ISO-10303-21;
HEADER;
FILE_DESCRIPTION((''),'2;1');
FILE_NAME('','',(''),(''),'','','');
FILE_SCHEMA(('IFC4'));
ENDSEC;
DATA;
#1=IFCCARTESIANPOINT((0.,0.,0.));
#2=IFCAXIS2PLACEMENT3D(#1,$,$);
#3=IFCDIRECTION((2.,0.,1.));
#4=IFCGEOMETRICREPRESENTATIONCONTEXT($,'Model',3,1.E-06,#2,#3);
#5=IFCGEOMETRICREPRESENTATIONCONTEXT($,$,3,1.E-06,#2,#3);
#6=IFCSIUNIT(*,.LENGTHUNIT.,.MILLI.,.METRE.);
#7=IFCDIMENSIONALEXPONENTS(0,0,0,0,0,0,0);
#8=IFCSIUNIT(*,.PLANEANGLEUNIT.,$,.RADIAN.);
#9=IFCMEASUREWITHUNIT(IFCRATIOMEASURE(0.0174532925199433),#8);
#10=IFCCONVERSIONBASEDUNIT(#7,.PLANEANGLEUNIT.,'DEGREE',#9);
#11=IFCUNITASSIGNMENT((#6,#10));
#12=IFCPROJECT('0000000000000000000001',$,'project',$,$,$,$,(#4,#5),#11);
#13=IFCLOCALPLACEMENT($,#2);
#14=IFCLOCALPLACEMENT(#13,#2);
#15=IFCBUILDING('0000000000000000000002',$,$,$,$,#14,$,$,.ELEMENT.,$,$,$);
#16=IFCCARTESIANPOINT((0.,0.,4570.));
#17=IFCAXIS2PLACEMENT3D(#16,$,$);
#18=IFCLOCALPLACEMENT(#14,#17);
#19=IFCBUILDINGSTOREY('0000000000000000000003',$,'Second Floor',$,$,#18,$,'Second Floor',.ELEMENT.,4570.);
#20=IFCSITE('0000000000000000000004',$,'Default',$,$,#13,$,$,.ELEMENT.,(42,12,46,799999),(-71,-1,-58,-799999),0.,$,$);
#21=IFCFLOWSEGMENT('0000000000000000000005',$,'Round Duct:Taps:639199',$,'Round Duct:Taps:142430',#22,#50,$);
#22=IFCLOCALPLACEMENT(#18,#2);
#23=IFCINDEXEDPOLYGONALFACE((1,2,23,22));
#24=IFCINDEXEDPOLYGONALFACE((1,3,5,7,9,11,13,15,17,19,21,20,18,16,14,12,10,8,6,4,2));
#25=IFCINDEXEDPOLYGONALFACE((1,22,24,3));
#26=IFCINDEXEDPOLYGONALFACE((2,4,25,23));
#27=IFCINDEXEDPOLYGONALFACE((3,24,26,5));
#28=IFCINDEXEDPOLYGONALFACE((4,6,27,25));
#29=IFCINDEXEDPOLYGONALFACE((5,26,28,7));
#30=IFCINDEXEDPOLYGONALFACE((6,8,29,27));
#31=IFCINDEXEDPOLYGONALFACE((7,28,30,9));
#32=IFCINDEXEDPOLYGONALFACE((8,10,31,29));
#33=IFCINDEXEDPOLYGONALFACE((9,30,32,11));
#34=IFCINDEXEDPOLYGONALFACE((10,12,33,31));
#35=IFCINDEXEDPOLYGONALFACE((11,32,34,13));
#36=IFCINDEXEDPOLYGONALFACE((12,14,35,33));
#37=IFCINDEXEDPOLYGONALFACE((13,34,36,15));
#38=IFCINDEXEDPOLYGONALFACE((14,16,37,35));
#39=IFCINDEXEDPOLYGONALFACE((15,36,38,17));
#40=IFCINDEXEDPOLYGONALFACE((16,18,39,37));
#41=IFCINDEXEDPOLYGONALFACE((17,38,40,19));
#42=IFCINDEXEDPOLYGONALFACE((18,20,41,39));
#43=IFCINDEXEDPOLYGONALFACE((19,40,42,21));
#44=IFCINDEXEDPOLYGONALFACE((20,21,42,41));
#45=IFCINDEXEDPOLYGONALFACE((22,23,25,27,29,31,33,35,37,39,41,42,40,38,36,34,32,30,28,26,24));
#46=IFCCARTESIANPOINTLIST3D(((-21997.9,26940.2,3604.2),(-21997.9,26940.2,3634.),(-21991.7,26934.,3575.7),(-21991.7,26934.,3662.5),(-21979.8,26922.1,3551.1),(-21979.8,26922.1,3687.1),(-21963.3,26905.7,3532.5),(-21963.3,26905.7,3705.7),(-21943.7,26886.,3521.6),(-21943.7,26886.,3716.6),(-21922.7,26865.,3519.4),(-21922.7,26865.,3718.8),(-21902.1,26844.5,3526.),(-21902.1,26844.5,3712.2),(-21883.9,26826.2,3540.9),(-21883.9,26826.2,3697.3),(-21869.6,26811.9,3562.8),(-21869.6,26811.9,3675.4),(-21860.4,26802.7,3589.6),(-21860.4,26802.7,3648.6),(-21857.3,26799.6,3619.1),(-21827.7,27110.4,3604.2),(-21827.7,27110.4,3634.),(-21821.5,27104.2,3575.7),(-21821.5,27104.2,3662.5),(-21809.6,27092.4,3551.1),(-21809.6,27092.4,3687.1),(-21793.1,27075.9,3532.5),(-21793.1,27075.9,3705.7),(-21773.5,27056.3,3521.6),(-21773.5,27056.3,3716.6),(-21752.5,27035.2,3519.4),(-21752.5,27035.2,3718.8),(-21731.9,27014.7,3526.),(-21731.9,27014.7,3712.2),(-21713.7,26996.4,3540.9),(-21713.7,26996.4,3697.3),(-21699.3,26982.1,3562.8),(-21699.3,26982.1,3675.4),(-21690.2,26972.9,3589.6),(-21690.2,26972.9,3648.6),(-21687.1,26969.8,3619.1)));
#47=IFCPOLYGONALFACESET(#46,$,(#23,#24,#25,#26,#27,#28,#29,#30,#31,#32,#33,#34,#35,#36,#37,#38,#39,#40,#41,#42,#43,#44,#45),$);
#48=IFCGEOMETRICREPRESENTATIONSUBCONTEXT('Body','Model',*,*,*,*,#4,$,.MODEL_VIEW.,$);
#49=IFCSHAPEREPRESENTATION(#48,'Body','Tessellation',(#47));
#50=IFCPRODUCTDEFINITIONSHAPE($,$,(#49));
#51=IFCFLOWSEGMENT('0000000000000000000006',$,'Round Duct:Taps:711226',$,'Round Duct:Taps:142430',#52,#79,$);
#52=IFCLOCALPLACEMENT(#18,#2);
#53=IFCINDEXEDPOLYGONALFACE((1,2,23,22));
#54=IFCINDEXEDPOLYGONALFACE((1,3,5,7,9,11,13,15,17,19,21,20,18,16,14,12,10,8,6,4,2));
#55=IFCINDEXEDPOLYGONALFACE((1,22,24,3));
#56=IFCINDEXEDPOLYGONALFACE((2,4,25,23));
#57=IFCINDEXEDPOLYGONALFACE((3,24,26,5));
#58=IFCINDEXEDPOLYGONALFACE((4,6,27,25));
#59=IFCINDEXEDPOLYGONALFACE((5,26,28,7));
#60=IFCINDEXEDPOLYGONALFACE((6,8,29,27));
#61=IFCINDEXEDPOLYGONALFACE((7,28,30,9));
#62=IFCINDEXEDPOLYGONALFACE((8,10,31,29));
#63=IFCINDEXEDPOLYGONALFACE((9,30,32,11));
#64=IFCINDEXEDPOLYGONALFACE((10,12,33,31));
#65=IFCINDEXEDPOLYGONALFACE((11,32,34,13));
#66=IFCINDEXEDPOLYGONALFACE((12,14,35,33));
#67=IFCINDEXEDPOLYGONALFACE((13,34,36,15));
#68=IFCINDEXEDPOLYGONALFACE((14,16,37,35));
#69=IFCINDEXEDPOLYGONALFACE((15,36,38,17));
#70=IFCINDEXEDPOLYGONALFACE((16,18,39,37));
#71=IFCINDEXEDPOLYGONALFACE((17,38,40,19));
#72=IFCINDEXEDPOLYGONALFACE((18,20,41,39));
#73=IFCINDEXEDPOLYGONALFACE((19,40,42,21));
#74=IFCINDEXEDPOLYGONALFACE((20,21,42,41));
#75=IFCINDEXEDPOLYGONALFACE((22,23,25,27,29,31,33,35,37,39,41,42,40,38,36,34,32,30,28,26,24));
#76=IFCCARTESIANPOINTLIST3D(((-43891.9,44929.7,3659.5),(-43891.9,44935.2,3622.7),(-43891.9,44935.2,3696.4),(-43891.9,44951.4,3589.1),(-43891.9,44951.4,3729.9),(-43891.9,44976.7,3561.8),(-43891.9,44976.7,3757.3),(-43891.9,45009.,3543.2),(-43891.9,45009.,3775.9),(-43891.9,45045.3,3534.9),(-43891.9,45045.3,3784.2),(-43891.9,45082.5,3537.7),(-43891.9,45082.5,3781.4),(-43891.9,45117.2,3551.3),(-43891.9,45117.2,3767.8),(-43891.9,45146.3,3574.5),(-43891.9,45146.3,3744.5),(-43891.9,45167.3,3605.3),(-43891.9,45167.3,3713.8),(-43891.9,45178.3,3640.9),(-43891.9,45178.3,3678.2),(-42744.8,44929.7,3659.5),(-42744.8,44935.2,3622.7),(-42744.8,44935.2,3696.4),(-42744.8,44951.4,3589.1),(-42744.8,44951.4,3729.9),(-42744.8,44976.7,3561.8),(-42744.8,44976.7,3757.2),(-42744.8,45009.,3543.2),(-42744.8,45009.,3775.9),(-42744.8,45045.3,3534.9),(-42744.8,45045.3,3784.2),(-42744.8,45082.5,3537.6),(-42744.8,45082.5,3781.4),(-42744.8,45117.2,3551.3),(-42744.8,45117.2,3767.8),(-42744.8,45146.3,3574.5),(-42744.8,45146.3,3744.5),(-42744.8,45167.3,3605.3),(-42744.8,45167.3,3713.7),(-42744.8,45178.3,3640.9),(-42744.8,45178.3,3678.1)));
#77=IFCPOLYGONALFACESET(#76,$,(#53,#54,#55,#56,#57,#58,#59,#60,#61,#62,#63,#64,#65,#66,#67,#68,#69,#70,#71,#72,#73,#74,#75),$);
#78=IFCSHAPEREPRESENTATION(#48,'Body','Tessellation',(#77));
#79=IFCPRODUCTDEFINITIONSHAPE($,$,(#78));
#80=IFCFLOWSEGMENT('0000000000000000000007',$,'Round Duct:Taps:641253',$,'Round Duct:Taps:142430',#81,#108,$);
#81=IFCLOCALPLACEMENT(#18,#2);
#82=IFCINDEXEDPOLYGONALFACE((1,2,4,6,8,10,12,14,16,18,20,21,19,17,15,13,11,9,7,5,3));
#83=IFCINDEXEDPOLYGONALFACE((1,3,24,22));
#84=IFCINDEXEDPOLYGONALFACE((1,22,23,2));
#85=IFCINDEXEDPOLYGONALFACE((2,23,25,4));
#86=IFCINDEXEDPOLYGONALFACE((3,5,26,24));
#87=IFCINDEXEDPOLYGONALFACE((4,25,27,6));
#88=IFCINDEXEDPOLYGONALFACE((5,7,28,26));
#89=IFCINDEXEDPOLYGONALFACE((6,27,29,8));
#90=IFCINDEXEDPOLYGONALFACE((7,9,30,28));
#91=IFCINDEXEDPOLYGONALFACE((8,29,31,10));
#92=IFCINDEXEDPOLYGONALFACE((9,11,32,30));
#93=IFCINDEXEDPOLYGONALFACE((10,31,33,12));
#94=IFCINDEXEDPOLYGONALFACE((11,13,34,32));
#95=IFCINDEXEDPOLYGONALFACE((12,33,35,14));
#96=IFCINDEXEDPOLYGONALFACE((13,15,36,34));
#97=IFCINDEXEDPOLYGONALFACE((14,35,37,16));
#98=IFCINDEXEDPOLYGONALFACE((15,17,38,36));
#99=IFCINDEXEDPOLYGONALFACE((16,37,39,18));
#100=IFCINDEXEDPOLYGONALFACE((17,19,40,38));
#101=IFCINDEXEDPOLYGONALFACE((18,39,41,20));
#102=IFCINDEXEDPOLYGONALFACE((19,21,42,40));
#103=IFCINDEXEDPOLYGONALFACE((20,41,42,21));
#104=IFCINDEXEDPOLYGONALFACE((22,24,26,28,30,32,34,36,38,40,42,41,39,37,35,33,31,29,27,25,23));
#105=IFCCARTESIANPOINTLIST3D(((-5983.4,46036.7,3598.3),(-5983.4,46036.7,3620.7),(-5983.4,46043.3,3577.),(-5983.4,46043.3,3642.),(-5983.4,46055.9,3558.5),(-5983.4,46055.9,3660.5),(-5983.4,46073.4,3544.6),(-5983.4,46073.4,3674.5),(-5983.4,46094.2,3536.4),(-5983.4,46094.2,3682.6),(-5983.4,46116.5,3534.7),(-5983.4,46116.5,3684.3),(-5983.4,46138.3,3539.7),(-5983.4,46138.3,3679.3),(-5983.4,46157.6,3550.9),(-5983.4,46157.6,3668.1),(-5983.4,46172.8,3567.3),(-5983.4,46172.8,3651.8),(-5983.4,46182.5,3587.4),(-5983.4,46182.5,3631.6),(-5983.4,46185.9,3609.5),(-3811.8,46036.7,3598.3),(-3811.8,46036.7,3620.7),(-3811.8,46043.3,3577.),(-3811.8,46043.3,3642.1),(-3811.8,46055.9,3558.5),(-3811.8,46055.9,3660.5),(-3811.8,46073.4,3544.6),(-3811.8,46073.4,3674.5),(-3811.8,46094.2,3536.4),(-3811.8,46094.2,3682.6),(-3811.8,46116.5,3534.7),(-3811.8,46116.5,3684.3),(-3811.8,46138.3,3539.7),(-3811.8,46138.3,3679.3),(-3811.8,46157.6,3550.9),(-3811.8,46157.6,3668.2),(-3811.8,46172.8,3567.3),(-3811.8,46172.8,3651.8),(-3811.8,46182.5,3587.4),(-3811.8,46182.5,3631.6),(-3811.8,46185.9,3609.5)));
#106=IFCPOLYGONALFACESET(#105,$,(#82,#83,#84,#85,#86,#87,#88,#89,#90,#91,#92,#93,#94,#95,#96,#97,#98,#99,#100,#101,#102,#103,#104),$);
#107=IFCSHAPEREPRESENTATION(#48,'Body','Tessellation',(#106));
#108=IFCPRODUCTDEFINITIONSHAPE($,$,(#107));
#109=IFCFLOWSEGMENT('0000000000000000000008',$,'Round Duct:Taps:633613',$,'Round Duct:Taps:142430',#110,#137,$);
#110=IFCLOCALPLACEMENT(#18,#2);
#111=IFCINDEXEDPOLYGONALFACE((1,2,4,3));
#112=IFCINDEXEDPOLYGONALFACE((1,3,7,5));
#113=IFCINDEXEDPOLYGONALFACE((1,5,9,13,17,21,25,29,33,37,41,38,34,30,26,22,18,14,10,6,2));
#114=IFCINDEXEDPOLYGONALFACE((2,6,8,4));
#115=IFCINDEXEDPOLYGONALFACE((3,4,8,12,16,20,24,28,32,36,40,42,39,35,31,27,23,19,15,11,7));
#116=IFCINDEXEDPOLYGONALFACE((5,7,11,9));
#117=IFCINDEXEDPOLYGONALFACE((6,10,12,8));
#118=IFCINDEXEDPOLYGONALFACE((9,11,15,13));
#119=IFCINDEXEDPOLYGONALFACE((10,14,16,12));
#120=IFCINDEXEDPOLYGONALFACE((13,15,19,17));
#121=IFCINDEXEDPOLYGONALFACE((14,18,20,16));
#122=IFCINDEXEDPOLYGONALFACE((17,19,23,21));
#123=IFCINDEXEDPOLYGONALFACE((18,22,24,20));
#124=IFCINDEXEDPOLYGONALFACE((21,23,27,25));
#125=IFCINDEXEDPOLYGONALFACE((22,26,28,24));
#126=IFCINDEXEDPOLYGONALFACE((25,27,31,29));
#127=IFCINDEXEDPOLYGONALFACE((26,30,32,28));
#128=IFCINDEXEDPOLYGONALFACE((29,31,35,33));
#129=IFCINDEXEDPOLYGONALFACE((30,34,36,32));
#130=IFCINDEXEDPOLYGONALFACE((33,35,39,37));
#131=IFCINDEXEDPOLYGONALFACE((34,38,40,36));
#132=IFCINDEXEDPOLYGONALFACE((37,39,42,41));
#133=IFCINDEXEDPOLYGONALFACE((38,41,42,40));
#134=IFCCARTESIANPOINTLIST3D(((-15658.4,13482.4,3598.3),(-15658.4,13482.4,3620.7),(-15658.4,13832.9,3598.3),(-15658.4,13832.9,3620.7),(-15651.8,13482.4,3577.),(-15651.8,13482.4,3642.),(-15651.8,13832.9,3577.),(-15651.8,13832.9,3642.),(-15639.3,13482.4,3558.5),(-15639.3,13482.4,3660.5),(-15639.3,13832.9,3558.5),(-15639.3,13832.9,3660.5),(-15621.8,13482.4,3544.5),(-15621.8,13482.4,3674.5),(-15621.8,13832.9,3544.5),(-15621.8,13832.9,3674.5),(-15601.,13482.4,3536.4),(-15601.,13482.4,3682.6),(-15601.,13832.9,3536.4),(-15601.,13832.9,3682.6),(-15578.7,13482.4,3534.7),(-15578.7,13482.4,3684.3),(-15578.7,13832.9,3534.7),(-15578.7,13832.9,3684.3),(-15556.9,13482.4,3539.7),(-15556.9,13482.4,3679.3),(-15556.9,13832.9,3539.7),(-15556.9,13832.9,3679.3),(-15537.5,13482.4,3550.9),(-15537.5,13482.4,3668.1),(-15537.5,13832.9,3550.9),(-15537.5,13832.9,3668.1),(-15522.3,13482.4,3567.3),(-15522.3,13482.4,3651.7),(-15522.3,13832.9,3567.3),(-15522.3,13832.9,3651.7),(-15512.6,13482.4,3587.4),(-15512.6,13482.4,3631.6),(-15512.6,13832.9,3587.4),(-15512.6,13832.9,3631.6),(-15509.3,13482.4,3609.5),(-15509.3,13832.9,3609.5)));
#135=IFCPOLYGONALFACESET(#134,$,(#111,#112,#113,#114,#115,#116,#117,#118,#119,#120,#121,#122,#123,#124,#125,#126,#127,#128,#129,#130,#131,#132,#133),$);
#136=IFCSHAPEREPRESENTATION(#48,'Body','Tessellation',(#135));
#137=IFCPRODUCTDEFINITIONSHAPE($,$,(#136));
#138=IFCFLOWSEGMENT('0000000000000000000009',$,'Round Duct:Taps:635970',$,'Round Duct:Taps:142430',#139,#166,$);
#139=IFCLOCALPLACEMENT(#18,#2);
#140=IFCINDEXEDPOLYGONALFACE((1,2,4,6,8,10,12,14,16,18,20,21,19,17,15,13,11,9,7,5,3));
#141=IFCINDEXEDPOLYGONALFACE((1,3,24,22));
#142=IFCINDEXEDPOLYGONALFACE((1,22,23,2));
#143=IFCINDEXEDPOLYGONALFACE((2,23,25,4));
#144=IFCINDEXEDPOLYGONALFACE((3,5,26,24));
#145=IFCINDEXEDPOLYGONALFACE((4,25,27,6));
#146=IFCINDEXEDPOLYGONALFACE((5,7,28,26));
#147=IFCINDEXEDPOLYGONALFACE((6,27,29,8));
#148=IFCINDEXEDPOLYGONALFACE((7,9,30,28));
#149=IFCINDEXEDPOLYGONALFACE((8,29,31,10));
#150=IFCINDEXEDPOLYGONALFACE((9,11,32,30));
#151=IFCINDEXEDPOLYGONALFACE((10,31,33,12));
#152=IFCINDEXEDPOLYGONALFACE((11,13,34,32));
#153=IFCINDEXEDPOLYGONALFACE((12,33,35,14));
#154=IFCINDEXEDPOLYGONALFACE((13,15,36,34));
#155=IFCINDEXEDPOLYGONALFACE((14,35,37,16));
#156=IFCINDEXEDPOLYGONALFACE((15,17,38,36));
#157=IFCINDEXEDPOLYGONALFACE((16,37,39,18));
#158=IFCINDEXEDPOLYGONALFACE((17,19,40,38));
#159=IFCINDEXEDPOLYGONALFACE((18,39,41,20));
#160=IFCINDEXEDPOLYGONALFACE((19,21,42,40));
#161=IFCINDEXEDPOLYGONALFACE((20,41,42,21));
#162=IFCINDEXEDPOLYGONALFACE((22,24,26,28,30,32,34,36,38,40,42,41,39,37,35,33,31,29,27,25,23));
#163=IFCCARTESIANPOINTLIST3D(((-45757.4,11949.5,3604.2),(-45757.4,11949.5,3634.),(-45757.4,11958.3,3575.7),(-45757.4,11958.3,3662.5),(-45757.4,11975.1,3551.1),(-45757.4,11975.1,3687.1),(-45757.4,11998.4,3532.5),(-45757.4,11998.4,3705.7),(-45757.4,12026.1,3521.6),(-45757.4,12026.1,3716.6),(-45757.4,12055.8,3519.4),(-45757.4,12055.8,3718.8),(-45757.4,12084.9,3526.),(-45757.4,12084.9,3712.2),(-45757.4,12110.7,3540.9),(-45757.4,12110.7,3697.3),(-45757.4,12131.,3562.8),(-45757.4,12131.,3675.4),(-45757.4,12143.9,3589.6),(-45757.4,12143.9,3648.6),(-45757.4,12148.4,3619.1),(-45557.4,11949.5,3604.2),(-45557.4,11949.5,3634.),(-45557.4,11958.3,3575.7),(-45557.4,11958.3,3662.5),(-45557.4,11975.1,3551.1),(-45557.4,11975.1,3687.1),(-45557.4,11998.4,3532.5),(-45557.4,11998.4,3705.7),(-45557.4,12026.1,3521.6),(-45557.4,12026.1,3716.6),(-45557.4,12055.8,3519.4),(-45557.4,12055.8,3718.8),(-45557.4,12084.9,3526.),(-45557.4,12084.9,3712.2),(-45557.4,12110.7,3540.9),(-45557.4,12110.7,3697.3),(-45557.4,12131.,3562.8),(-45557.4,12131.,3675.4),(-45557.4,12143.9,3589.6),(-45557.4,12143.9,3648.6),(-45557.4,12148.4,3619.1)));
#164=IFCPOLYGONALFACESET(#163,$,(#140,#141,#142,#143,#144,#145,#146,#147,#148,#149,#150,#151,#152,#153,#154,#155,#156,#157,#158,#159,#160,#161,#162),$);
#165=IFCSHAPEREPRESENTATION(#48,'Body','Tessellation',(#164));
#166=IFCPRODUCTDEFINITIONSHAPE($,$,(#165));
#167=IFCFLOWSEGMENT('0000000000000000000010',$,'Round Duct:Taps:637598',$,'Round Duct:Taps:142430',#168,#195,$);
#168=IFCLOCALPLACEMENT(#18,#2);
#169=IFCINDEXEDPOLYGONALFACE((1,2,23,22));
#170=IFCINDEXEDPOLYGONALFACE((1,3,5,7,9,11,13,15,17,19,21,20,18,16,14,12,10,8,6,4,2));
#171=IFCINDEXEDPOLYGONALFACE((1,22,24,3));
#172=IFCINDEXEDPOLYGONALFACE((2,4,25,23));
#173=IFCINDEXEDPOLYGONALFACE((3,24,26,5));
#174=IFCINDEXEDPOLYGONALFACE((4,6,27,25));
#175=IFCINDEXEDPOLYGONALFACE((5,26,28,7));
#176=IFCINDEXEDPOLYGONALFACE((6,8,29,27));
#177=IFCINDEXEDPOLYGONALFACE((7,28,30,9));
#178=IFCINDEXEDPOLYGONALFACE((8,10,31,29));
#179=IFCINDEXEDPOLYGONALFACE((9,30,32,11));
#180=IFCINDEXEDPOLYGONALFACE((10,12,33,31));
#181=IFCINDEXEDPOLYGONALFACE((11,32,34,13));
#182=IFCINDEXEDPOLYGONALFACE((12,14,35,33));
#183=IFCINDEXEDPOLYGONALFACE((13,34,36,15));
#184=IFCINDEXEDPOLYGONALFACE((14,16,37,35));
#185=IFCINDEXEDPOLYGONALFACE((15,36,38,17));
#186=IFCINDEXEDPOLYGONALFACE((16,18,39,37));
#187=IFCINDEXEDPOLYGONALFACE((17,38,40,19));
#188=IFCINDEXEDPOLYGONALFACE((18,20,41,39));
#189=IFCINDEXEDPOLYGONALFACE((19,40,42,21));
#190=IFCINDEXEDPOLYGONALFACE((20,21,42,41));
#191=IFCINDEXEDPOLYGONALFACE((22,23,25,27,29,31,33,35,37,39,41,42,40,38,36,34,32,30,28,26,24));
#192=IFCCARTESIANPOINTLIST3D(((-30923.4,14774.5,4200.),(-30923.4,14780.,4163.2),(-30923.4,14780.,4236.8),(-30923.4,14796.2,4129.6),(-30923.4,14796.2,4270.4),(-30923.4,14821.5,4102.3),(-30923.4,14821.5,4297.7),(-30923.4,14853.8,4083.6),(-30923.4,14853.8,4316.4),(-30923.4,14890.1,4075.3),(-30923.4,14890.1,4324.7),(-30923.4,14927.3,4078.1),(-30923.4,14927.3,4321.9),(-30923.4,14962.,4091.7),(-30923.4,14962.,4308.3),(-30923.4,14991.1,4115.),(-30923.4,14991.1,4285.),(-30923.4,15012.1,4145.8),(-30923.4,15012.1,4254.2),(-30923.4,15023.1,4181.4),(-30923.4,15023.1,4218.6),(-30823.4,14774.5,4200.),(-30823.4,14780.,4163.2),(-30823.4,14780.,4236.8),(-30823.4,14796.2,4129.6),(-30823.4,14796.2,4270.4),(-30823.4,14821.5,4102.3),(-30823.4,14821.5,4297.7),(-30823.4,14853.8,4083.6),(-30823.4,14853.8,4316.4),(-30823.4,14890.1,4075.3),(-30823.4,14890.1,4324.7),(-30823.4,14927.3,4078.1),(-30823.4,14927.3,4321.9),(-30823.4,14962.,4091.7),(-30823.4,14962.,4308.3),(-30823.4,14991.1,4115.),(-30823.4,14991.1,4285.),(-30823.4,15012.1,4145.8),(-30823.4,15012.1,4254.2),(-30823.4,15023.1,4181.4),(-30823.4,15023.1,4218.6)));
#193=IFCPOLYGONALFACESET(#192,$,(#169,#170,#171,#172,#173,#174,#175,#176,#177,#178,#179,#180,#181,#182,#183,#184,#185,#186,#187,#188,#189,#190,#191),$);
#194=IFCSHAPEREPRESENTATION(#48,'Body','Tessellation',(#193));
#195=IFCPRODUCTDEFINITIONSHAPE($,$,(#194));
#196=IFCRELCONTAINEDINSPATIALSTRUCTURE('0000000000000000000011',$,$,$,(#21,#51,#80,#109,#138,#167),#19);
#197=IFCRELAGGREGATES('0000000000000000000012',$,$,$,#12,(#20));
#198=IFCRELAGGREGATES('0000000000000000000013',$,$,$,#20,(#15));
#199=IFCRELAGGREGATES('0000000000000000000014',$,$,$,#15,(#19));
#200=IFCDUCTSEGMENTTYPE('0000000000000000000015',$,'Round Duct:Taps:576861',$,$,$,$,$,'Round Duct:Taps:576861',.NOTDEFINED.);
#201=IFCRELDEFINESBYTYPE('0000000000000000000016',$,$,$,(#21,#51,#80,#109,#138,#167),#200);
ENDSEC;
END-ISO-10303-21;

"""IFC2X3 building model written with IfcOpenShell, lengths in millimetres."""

from ifc_helpers import new_model, entity, si_unit, converted_unit, direction, frame, frame_2d, origin, origin_2d_with_axis, place, context, subcontext, project, spatial, circle, extrude, type_object, element, save


model = new_model("IFC2X3")

# Units and contexts
model_context = context("Model", 3, precision=1e-06, world=origin(), true_north=direction((2.0, 0.0, 1.0)))
context_of_model = context(None, 3, precision=1e-06, world=origin(), true_north=direction((2.0, 0.0, 1.0)))
body_context = subcontext(model_context, "Body", "Model", "MODEL_VIEW")
ifc_project = project(units=[si_unit("LENGTHUNIT", "METRE", prefix="MILLI"), converted_unit("PLANEANGLEUNIT", "DEGREE", entity("IfcRatioMeasure", 0.0174532925199433), si_unit("PLANEANGLEUNIT", "RADIAN"), dimensions=[0, 0, 0, 0, 0, 0, 0])], contexts=[model_context, context_of_model])

# Site, building, storey
site_placement = place(None, origin())
site = spatial("IfcSite", under=ifc_project, at=site_placement, Name="Default", CompositionType="ELEMENT", RefLatitude=(42, 12, 46, 799999), RefLongitude=(-71, -1, -58, -799999), RefElevation=0.0)
building_placement = place(site_placement, origin())
building = spatial("IfcBuilding", under=site, at=building_placement, CompositionType="ELEMENT")
storey_placement = place(building_placement, frame((0.0, 0.0, 4570.0)))
storey = spatial("IfcBuildingStorey", under=building, at=storey_placement, Name="Second Floor", LongName="Second Floor", CompositionType="ELEMENT", Elevation=4570.0)

# Flow segments
duct_segment_type_1 = type_object("IfcDuctSegmentType", Name="Round Duct:Taps:576861", ElementType="Round Duct:Taps:576861", PredefinedType="NOTDEFINED")
flow_segment_1_placement = place(storey_placement, origin())
element("IfcFlowSegment", 1, at=flow_segment_1_placement, inside=storey, type_object=duct_segment_type_1, Name="Round Duct:Taps:639199", ObjectType="Round Duct:Taps:142430", context=body_context, shape_type="SweptSolid", body=[
    extrude(circle(Radius=100.0, at=origin_2d_with_axis()), frame((-21928.0, 26870.3, 3619.1), z_axis=(0.707107, 0.707107, 0.0), x_axis=(0.707107, -0.707107, 0.0)), (0.0, 0.0, 1.0), 240.7),
])
flow_segment_2_placement = place(storey_placement, origin())
element("IfcFlowSegment", 2, at=flow_segment_2_placement, inside=storey, type_object=duct_segment_type_1, Name="Round Duct:Taps:711226", ObjectType="Round Duct:Taps:142430", context=body_context, shape_type="SweptSolid", body=[
    extrude(circle(Radius=125.0, at=frame_2d((0.0, 0.0), x_axis=(1.0, 0.0))), frame((-42744.8, 45054.7, 3659.5), z_axis=(-1.0, 0.0, 0.000013), x_axis=(0.0, -1.0, 0.0)), (0.0, 0.0, 1.0), 1147.1),
])
flow_segment_3_placement = place(storey_placement, origin())
element("IfcFlowSegment", 3, at=flow_segment_3_placement, inside=storey, type_object=duct_segment_type_1, Name="Round Duct:Taps:641253", ObjectType="Round Duct:Taps:142430", context=body_context, shape_type="SweptSolid", body=[
    extrude(circle(Radius=75.0, at=frame_2d((0.0, 0.0), x_axis=(1.0, 0.0))), frame((-5983.4, 46110.9, 3609.5), z_axis=(1.0, 0.0, 0.00001), x_axis=(0.0, 1.0, 0.0)), (0.0, 0.0, 1.0), 2171.6),
])
flow_segment_4_placement = place(storey_placement, origin())
element("IfcFlowSegment", 4, at=flow_segment_4_placement, inside=storey, type_object=duct_segment_type_1, Name="Round Duct:Taps:633613", ObjectType="Round Duct:Taps:142430", context=body_context, shape_type="SweptSolid", body=[
    extrude(circle(Radius=75.0, at=origin_2d_with_axis()), frame((-15584.3, 13482.4, 3609.5), z_axis=(0.0, 1.0, 0.0), x_axis=(1.0, 0.0, 0.0)), (0.0, 0.0, 1.0), 350.5),
])
flow_segment_5_placement = place(storey_placement, origin())
element("IfcFlowSegment", 5, at=flow_segment_5_placement, inside=storey, type_object=duct_segment_type_1, Name="Round Duct:Taps:635970", ObjectType="Round Duct:Taps:142430", context=body_context, shape_type="SweptSolid", body=[
    extrude(circle(Radius=100.0, at=frame_2d((0.0, 0.0), x_axis=(1.0, 0.0))), frame((-45757.4, 12048.4, 3619.1), z_axis=(1.0, 0.0, 0.0), x_axis=(0.0, 1.0, 0.0)), (0.0, 0.0, 1.0), 200.0),
])
flow_segment_6_placement = place(storey_placement, origin())
element("IfcFlowSegment", 6, at=flow_segment_6_placement, inside=storey, type_object=duct_segment_type_1, Name="Round Duct:Taps:637598", ObjectType="Round Duct:Taps:142430", context=body_context, shape_type="SweptSolid", body=[
    extrude(circle(Radius=125.0, at=frame_2d((0.0, 0.0), x_axis=(1.0, 0.0))), frame((-30923.4, 14899.5, 4200.0), z_axis=(1.0, 0.0, 0.0), x_axis=(0.0, -1.0, 0.0)), (0.0, 0.0, 1.0), 100.0),
])

save(model, "model.ifc")
